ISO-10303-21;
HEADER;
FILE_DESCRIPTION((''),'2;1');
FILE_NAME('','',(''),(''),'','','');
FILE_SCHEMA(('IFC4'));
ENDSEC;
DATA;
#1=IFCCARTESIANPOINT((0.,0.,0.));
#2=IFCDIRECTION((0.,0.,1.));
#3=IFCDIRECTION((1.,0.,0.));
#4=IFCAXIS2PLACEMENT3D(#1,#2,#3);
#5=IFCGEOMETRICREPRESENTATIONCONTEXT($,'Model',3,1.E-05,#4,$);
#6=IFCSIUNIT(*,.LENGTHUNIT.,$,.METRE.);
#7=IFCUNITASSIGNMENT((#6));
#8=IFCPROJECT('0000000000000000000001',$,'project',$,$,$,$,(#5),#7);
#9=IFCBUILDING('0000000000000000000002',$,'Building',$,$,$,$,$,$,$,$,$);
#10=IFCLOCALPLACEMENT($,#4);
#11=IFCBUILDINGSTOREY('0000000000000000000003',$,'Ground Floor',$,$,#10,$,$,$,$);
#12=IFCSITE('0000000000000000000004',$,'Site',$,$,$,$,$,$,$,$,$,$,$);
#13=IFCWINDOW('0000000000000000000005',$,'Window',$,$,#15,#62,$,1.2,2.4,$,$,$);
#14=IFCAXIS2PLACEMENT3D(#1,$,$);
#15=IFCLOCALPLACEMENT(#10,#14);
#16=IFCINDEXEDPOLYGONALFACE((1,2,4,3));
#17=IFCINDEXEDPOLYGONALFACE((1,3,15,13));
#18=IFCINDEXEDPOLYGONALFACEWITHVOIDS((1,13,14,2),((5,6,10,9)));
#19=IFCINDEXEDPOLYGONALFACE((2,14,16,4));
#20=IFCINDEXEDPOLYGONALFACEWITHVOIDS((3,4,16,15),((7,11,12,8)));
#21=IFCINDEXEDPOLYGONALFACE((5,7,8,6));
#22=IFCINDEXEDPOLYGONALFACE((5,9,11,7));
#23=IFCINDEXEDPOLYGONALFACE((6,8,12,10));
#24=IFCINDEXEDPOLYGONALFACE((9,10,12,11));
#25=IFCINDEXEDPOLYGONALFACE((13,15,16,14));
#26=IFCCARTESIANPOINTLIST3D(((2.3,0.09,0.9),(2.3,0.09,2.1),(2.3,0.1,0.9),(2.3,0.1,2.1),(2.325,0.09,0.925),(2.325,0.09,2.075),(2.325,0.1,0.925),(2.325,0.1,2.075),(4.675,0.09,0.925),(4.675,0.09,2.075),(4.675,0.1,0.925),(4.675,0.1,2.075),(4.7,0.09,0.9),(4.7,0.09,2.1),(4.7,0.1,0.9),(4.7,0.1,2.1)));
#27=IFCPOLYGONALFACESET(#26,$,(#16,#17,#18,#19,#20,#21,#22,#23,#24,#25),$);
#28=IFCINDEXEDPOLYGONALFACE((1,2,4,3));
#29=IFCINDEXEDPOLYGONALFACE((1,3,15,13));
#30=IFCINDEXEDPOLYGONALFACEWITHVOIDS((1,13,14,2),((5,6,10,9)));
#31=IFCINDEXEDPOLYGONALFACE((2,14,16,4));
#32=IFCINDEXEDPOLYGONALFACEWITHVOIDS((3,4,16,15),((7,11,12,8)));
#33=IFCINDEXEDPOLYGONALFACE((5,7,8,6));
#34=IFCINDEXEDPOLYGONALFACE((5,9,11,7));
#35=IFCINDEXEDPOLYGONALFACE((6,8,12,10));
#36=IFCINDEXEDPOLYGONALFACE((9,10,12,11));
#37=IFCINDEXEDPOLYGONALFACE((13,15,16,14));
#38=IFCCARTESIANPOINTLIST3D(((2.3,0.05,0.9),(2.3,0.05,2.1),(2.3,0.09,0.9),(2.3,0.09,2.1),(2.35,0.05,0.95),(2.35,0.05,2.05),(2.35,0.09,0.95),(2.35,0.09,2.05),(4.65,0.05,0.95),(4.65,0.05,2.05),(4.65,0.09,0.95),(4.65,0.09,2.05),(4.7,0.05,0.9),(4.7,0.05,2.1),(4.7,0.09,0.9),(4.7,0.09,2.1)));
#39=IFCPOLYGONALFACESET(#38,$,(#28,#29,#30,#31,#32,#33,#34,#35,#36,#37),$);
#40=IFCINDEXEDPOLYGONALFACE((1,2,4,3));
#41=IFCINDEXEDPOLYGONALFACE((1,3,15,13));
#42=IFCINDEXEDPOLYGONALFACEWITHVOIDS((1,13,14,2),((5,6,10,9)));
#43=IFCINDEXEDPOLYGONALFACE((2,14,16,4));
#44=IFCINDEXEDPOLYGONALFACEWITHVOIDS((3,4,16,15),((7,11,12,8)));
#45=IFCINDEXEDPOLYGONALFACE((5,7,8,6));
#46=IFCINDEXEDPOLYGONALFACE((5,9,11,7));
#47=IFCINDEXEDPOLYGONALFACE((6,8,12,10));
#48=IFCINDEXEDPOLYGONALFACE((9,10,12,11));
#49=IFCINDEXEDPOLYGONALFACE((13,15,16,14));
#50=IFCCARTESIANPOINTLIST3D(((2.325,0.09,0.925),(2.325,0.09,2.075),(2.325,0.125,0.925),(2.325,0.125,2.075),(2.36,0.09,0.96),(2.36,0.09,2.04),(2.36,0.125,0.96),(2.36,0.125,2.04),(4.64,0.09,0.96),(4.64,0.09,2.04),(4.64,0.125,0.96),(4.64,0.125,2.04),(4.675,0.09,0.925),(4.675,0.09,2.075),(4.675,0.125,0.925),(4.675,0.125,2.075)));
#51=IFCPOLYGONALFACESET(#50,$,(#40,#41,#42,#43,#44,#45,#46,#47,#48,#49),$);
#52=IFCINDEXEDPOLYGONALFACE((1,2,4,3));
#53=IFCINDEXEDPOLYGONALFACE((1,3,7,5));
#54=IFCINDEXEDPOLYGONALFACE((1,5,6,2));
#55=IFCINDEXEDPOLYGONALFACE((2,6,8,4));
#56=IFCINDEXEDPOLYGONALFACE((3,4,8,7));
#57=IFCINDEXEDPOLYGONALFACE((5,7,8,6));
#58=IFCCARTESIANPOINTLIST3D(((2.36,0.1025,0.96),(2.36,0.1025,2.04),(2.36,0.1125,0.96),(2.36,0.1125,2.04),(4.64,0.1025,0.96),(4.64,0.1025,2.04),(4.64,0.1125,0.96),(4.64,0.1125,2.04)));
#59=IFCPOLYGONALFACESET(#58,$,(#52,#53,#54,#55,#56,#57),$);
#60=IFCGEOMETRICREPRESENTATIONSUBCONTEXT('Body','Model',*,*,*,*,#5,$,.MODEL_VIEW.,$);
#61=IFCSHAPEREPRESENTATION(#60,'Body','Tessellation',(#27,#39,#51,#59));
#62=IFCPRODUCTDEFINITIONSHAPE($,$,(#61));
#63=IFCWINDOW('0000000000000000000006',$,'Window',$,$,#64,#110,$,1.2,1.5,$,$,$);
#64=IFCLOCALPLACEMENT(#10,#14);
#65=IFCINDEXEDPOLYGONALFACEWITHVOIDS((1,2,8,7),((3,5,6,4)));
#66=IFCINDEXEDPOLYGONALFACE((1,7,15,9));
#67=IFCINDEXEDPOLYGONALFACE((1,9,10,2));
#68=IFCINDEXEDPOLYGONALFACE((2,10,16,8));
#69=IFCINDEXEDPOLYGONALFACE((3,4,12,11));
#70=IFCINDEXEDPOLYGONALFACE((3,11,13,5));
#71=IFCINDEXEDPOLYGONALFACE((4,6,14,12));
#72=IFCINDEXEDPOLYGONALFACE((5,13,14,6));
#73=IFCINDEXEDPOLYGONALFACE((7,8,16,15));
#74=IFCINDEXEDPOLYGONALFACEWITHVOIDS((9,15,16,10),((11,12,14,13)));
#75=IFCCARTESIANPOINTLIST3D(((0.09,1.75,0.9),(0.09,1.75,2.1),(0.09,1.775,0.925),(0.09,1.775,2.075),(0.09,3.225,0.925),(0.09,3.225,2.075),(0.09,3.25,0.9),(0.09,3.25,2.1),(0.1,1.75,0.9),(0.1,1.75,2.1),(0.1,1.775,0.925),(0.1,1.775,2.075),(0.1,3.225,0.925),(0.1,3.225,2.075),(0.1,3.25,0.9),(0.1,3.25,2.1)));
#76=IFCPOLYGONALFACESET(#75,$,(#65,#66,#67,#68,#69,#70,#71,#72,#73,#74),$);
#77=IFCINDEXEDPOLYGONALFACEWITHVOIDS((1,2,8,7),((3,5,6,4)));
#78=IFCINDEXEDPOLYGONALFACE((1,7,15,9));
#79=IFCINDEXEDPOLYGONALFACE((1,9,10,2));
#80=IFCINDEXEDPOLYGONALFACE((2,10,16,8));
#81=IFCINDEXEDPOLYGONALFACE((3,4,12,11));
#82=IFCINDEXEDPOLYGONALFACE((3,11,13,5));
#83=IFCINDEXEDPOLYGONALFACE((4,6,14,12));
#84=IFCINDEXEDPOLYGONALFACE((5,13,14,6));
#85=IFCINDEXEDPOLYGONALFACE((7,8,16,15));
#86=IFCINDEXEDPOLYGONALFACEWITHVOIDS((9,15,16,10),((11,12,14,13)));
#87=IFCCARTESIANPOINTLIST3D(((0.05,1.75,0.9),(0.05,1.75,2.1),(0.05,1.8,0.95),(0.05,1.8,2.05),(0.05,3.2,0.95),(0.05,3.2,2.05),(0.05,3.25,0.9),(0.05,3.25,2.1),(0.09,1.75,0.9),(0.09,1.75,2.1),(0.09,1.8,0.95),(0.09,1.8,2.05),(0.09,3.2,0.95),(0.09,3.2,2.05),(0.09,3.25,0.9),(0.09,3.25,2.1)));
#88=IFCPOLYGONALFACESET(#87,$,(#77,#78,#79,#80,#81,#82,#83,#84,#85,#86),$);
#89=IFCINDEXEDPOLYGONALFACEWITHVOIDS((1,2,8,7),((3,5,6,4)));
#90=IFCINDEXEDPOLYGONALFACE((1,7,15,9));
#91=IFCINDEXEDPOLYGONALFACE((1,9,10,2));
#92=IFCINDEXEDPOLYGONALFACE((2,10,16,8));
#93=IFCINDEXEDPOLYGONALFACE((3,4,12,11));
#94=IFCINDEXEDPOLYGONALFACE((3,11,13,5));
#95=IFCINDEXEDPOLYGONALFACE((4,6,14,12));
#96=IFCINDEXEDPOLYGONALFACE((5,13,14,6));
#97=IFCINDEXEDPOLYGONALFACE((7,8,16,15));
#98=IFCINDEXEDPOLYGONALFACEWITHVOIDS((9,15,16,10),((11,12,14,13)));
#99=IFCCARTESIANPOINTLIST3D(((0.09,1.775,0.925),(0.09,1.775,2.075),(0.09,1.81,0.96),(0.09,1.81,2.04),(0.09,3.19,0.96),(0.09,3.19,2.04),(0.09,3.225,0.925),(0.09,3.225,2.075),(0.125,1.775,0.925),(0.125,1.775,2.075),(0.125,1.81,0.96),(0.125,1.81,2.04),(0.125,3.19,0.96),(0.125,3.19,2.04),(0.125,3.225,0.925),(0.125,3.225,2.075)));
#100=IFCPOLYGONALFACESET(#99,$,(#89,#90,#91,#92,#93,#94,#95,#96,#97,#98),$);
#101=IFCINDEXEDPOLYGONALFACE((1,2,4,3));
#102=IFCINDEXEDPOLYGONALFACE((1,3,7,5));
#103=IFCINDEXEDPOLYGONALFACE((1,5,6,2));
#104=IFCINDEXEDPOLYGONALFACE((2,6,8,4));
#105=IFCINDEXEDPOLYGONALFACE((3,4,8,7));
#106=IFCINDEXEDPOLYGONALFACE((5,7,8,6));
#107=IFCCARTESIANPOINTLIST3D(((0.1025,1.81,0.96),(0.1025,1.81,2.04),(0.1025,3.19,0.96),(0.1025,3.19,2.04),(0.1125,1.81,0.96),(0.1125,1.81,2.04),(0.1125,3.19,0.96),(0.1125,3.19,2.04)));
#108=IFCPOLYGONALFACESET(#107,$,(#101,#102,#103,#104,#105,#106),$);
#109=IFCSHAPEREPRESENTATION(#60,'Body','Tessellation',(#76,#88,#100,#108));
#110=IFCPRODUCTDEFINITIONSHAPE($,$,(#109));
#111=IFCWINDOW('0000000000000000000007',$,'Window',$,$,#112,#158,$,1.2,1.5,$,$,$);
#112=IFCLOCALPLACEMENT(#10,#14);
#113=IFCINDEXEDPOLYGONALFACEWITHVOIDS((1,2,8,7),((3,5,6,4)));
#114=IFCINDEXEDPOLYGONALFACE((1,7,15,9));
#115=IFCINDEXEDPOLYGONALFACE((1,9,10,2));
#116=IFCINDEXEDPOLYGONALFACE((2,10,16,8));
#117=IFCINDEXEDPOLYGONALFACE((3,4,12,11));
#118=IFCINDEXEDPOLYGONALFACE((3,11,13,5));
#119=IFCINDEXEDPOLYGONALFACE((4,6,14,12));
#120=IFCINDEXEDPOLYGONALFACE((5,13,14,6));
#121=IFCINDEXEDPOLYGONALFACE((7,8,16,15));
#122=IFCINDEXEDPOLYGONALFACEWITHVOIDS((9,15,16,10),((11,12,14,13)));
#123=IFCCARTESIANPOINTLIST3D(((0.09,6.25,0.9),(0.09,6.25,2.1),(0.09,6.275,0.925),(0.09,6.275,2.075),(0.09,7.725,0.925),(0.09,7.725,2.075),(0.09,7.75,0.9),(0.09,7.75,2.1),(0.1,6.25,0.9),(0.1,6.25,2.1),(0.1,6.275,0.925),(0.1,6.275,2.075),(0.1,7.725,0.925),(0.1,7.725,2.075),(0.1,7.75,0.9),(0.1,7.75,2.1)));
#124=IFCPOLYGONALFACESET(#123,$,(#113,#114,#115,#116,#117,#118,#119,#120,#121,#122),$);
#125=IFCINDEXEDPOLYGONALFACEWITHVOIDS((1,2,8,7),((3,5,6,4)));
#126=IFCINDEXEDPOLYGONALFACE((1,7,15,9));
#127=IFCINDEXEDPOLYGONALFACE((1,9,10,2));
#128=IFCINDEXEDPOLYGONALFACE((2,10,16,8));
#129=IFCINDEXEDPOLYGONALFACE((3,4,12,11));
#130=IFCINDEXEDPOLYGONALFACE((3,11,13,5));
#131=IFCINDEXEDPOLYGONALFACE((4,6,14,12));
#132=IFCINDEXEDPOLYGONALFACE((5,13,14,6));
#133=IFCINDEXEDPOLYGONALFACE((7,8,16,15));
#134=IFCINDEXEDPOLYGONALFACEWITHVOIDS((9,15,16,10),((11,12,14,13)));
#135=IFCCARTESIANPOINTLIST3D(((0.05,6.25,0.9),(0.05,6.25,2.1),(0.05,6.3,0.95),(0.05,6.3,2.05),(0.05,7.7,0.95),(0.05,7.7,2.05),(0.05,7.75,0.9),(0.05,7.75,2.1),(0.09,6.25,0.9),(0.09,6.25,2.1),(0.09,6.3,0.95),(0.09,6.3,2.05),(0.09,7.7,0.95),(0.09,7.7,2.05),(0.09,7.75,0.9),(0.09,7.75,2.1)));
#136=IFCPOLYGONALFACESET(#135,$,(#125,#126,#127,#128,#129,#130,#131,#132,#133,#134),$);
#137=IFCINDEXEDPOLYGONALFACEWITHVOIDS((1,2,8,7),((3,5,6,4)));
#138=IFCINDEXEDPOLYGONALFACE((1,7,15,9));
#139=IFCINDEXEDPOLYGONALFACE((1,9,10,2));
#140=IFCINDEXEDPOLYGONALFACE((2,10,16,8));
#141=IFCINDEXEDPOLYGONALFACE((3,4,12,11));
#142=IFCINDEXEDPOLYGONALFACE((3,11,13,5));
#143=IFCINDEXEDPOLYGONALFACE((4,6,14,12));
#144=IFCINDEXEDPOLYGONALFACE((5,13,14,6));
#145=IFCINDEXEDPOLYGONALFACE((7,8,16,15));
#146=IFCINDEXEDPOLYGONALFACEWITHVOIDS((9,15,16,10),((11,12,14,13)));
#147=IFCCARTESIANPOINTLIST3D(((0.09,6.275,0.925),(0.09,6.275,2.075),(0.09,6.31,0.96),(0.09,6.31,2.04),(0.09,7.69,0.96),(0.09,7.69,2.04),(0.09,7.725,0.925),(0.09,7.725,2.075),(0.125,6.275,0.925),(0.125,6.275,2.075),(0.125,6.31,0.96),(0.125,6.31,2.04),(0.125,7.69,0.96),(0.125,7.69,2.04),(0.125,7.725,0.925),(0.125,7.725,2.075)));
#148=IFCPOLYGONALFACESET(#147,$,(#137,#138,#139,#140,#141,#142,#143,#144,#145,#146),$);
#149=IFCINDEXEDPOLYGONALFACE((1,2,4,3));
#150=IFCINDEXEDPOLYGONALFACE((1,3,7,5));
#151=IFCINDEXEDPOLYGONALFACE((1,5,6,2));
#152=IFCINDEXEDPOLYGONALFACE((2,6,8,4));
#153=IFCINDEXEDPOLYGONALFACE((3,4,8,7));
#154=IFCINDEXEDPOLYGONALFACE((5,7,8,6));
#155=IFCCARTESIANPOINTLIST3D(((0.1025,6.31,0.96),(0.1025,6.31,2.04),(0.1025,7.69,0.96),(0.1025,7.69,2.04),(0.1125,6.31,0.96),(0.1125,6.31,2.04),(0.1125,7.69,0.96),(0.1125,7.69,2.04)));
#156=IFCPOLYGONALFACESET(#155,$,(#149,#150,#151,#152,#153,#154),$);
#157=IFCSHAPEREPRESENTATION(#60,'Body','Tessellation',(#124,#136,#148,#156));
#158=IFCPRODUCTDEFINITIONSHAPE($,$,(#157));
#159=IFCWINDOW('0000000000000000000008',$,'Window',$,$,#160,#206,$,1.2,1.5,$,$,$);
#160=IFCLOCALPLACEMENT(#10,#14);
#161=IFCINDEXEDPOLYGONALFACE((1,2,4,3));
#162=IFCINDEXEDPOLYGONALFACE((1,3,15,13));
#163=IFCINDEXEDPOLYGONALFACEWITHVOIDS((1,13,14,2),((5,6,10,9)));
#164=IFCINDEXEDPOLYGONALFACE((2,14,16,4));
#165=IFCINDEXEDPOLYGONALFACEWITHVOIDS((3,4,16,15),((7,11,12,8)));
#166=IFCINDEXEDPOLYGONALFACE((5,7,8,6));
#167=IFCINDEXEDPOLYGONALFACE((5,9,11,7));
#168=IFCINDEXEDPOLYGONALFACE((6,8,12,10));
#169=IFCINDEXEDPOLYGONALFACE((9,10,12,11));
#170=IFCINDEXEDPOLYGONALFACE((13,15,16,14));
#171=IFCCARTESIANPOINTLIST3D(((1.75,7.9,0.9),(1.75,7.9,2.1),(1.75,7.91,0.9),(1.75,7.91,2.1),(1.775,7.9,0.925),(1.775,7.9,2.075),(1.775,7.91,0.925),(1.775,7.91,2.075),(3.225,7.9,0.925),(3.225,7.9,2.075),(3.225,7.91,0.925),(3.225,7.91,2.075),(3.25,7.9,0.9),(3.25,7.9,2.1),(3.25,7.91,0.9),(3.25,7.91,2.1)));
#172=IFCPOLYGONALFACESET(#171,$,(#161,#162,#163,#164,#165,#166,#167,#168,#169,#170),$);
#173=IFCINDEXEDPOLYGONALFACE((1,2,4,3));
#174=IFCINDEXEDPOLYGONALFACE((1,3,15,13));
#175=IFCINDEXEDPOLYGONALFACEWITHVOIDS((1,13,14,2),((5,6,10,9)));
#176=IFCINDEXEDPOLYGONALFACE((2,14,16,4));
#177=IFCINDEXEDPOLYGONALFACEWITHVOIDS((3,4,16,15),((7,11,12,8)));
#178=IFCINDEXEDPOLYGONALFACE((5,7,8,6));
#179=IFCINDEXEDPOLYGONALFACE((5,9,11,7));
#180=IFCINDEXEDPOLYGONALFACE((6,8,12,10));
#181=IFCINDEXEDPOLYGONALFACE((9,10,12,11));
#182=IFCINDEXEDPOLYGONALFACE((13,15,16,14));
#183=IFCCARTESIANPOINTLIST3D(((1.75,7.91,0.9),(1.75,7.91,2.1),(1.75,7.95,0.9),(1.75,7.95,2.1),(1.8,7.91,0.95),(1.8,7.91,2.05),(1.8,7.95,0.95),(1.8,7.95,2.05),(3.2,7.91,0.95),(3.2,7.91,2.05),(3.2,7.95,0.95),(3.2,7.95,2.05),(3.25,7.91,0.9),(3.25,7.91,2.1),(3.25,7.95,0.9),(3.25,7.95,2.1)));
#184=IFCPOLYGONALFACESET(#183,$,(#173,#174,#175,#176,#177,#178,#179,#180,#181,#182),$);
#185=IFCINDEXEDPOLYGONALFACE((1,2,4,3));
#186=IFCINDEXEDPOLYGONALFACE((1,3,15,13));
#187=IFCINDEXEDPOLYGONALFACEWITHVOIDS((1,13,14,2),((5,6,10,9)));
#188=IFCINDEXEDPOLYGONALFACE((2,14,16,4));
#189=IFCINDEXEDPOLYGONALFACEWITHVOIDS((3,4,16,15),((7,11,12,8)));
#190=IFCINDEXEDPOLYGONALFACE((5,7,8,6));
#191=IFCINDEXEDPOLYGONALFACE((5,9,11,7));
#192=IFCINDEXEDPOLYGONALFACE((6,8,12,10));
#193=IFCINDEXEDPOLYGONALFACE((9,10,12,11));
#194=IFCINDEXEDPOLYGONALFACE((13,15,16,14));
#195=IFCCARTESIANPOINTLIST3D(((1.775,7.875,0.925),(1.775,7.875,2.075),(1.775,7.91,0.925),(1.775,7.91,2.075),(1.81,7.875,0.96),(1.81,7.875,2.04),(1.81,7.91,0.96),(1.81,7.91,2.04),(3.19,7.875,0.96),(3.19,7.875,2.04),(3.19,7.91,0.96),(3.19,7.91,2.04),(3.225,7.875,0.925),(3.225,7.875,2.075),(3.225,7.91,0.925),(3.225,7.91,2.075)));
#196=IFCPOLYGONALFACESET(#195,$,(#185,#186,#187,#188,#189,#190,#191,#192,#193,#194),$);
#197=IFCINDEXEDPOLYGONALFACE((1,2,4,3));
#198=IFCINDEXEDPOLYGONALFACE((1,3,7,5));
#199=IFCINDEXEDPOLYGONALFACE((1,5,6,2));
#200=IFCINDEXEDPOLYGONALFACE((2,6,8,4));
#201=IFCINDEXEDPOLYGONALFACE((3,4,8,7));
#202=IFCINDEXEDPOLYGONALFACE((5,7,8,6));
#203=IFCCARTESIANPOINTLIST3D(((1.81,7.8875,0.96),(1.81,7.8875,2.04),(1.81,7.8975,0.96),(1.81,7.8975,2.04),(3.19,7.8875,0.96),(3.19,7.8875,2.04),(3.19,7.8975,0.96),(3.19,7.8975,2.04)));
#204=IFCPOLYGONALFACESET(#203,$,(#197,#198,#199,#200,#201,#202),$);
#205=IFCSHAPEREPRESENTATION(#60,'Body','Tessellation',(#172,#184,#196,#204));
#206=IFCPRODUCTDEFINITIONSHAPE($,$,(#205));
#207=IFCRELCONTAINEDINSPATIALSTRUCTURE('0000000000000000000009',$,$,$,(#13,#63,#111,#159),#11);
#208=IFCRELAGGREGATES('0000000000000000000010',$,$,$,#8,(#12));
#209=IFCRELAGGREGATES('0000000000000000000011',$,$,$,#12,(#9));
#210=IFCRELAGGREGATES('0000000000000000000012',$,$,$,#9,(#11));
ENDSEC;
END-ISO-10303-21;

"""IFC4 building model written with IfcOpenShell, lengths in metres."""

from ifc_helpers import new_model, si_unit, frame, origin_with_axes, place, context, subcontext, project, spatial, line, indexed_curve, outline, extrude, element, save


model = new_model("IFC4")

# Units and contexts
model_context = context("Model", 3, precision=1e-05, world=origin_with_axes())
body_context = subcontext(model_context, "Body", "Model", "MODEL_VIEW")
ifc_project = project(units=[si_unit("LENGTHUNIT", "METRE")], contexts=[model_context])

# Site, building, storey
site = spatial("IfcSite", under=ifc_project, Name="Site")
building = spatial("IfcBuilding", under=site, Name="Building")
storey_placement = place(None, origin_with_axes())
storey = spatial("IfcBuildingStorey", under=building, at=storey_placement, Name="Ground Floor")

# Windows
window_placement = place(storey_placement, frame((2.3, 0.0, 0.9), z_axis=(0.0, 0.0, 1.0), x_axis=(1.0, 0.0, 0.0)))
element("IfcWindow", 1, at=window_placement, inside=storey, Name="Window", OverallHeight=1.2, OverallWidth=2.4, context=body_context, shape_type="SweptSolid", body=[
    extrude(outline(indexed_curve([(0.0, 0.0), (2.4, 0.0), (2.4, 1.2), (0.0, 1.2)], segments=[line(1, 2, 3, 4, 1)]), holes=[indexed_curve([(0.025, 0.025), (2.375, 0.025), (2.375, 1.175), (0.025, 1.175)], segments=[line(1, 2, 3, 4, 1)])]), frame((0.0, 0.09, 0.0), z_axis=(0.0, -1.0, 0.0), x_axis=(1.0, 0.0, 0.0)), (0.0, 0.0, -1.0), 0.01),
    extrude(outline(indexed_curve([(0.0, 0.0), (2.4, 0.0), (2.4, 1.2), (0.0, 1.2)], segments=[line(1, 2, 3, 4, 1)]), holes=[indexed_curve([(0.05, 0.05), (2.35, 0.05), (2.35, 1.15), (0.05, 1.15)], segments=[line(1, 2, 3, 4, 1)])]), frame((0.0, 0.05, 0.0), z_axis=(0.0, -1.0, 0.0), x_axis=(1.0, 0.0, 0.0)), (0.0, 0.0, -1.0), 0.04),
    extrude(outline(indexed_curve([(0.0, 0.0), (2.35, 0.0), (2.35, 1.15), (0.0, 1.15)], segments=[line(1, 2, 3, 4, 1)]), holes=[indexed_curve([(0.035, 0.035), (2.315, 0.035), (2.315, 1.115), (0.035, 1.115)], segments=[line(1, 2, 3, 4, 1)])]), frame((0.025, 0.09, 0.025), z_axis=(0.0, -1.0, 0.0), x_axis=(1.0, 0.0, 0.0)), (0.0, 0.0, -1.0), 0.035),
    extrude(outline(indexed_curve([(0.035, 0.035), (2.315, 0.035), (2.315, 1.115), (0.035, 1.115)], segments=[line(1, 2, 3, 4, 1)])), frame((0.025, 0.1025, 0.025), z_axis=(0.0, -1.0, 0.0), x_axis=(1.0, 0.0, 0.0)), (0.0, 0.0, -1.0), 0.01),
])
for number, where, z_axis, x_axis, name in (
    (2, (0.0, 3.25, 0.9), (0.0, 0.0, 1.0), (0.0, -1.0, 0.0), "Window"),
    (3, (0.0, 7.75, 0.9), (0.0, 0.0, 1.0), (0.0, -1.0, 0.0), "Window"),
    (4, (3.25, 8.0, 0.9), (0.0, 0.0, 1.0), (-1.0, 0.0, 0.0), "Window"),
):
    element("IfcWindow", number, at=place(storey_placement, frame(where, z_axis=z_axis, x_axis=x_axis)), inside=storey, Name=name, OverallHeight=1.2, OverallWidth=1.5, context=body_context, shape_type="SweptSolid", body=[
        extrude(outline(indexed_curve([(0.0, 0.0), (1.5, 0.0), (1.5, 1.2), (0.0, 1.2)], segments=[line(1, 2, 3, 4, 1)]), holes=[indexed_curve([(0.025, 0.025), (1.475, 0.025), (1.475, 1.175), (0.025, 1.175)], segments=[line(1, 2, 3, 4, 1)])]), frame((0.0, 0.09, 0.0), z_axis=(0.0, -1.0, 0.0), x_axis=(1.0, 0.0, 0.0)), (0.0, 0.0, -1.0), 0.01),
        extrude(outline(indexed_curve([(0.0, 0.0), (1.5, 0.0), (1.5, 1.2), (0.0, 1.2)], segments=[line(1, 2, 3, 4, 1)]), holes=[indexed_curve([(0.05, 0.05), (1.45, 0.05), (1.45, 1.15), (0.05, 1.15)], segments=[line(1, 2, 3, 4, 1)])]), frame((0.0, 0.05, 0.0), z_axis=(0.0, -1.0, 0.0), x_axis=(1.0, 0.0, 0.0)), (0.0, 0.0, -1.0), 0.04),
        extrude(outline(indexed_curve([(0.0, 0.0), (1.45, 0.0), (1.45, 1.15), (0.0, 1.15)], segments=[line(1, 2, 3, 4, 1)]), holes=[indexed_curve([(0.035, 0.035), (1.415, 0.035), (1.415, 1.115), (0.035, 1.115)], segments=[line(1, 2, 3, 4, 1)])]), frame((0.025, 0.09, 0.025), z_axis=(0.0, -1.0, 0.0), x_axis=(1.0, 0.0, 0.0)), (0.0, 0.0, -1.0), 0.035),
        extrude(outline(indexed_curve([(0.035, 0.035), (1.415, 0.035), (1.415, 1.115), (0.035, 1.115)], segments=[line(1, 2, 3, 4, 1)])), frame((0.025, 0.1025, 0.025), z_axis=(0.0, -1.0, 0.0), x_axis=(1.0, 0.0, 0.0)), (0.0, 0.0, -1.0), 0.01),
    ])

save(model, "model.ifc")
